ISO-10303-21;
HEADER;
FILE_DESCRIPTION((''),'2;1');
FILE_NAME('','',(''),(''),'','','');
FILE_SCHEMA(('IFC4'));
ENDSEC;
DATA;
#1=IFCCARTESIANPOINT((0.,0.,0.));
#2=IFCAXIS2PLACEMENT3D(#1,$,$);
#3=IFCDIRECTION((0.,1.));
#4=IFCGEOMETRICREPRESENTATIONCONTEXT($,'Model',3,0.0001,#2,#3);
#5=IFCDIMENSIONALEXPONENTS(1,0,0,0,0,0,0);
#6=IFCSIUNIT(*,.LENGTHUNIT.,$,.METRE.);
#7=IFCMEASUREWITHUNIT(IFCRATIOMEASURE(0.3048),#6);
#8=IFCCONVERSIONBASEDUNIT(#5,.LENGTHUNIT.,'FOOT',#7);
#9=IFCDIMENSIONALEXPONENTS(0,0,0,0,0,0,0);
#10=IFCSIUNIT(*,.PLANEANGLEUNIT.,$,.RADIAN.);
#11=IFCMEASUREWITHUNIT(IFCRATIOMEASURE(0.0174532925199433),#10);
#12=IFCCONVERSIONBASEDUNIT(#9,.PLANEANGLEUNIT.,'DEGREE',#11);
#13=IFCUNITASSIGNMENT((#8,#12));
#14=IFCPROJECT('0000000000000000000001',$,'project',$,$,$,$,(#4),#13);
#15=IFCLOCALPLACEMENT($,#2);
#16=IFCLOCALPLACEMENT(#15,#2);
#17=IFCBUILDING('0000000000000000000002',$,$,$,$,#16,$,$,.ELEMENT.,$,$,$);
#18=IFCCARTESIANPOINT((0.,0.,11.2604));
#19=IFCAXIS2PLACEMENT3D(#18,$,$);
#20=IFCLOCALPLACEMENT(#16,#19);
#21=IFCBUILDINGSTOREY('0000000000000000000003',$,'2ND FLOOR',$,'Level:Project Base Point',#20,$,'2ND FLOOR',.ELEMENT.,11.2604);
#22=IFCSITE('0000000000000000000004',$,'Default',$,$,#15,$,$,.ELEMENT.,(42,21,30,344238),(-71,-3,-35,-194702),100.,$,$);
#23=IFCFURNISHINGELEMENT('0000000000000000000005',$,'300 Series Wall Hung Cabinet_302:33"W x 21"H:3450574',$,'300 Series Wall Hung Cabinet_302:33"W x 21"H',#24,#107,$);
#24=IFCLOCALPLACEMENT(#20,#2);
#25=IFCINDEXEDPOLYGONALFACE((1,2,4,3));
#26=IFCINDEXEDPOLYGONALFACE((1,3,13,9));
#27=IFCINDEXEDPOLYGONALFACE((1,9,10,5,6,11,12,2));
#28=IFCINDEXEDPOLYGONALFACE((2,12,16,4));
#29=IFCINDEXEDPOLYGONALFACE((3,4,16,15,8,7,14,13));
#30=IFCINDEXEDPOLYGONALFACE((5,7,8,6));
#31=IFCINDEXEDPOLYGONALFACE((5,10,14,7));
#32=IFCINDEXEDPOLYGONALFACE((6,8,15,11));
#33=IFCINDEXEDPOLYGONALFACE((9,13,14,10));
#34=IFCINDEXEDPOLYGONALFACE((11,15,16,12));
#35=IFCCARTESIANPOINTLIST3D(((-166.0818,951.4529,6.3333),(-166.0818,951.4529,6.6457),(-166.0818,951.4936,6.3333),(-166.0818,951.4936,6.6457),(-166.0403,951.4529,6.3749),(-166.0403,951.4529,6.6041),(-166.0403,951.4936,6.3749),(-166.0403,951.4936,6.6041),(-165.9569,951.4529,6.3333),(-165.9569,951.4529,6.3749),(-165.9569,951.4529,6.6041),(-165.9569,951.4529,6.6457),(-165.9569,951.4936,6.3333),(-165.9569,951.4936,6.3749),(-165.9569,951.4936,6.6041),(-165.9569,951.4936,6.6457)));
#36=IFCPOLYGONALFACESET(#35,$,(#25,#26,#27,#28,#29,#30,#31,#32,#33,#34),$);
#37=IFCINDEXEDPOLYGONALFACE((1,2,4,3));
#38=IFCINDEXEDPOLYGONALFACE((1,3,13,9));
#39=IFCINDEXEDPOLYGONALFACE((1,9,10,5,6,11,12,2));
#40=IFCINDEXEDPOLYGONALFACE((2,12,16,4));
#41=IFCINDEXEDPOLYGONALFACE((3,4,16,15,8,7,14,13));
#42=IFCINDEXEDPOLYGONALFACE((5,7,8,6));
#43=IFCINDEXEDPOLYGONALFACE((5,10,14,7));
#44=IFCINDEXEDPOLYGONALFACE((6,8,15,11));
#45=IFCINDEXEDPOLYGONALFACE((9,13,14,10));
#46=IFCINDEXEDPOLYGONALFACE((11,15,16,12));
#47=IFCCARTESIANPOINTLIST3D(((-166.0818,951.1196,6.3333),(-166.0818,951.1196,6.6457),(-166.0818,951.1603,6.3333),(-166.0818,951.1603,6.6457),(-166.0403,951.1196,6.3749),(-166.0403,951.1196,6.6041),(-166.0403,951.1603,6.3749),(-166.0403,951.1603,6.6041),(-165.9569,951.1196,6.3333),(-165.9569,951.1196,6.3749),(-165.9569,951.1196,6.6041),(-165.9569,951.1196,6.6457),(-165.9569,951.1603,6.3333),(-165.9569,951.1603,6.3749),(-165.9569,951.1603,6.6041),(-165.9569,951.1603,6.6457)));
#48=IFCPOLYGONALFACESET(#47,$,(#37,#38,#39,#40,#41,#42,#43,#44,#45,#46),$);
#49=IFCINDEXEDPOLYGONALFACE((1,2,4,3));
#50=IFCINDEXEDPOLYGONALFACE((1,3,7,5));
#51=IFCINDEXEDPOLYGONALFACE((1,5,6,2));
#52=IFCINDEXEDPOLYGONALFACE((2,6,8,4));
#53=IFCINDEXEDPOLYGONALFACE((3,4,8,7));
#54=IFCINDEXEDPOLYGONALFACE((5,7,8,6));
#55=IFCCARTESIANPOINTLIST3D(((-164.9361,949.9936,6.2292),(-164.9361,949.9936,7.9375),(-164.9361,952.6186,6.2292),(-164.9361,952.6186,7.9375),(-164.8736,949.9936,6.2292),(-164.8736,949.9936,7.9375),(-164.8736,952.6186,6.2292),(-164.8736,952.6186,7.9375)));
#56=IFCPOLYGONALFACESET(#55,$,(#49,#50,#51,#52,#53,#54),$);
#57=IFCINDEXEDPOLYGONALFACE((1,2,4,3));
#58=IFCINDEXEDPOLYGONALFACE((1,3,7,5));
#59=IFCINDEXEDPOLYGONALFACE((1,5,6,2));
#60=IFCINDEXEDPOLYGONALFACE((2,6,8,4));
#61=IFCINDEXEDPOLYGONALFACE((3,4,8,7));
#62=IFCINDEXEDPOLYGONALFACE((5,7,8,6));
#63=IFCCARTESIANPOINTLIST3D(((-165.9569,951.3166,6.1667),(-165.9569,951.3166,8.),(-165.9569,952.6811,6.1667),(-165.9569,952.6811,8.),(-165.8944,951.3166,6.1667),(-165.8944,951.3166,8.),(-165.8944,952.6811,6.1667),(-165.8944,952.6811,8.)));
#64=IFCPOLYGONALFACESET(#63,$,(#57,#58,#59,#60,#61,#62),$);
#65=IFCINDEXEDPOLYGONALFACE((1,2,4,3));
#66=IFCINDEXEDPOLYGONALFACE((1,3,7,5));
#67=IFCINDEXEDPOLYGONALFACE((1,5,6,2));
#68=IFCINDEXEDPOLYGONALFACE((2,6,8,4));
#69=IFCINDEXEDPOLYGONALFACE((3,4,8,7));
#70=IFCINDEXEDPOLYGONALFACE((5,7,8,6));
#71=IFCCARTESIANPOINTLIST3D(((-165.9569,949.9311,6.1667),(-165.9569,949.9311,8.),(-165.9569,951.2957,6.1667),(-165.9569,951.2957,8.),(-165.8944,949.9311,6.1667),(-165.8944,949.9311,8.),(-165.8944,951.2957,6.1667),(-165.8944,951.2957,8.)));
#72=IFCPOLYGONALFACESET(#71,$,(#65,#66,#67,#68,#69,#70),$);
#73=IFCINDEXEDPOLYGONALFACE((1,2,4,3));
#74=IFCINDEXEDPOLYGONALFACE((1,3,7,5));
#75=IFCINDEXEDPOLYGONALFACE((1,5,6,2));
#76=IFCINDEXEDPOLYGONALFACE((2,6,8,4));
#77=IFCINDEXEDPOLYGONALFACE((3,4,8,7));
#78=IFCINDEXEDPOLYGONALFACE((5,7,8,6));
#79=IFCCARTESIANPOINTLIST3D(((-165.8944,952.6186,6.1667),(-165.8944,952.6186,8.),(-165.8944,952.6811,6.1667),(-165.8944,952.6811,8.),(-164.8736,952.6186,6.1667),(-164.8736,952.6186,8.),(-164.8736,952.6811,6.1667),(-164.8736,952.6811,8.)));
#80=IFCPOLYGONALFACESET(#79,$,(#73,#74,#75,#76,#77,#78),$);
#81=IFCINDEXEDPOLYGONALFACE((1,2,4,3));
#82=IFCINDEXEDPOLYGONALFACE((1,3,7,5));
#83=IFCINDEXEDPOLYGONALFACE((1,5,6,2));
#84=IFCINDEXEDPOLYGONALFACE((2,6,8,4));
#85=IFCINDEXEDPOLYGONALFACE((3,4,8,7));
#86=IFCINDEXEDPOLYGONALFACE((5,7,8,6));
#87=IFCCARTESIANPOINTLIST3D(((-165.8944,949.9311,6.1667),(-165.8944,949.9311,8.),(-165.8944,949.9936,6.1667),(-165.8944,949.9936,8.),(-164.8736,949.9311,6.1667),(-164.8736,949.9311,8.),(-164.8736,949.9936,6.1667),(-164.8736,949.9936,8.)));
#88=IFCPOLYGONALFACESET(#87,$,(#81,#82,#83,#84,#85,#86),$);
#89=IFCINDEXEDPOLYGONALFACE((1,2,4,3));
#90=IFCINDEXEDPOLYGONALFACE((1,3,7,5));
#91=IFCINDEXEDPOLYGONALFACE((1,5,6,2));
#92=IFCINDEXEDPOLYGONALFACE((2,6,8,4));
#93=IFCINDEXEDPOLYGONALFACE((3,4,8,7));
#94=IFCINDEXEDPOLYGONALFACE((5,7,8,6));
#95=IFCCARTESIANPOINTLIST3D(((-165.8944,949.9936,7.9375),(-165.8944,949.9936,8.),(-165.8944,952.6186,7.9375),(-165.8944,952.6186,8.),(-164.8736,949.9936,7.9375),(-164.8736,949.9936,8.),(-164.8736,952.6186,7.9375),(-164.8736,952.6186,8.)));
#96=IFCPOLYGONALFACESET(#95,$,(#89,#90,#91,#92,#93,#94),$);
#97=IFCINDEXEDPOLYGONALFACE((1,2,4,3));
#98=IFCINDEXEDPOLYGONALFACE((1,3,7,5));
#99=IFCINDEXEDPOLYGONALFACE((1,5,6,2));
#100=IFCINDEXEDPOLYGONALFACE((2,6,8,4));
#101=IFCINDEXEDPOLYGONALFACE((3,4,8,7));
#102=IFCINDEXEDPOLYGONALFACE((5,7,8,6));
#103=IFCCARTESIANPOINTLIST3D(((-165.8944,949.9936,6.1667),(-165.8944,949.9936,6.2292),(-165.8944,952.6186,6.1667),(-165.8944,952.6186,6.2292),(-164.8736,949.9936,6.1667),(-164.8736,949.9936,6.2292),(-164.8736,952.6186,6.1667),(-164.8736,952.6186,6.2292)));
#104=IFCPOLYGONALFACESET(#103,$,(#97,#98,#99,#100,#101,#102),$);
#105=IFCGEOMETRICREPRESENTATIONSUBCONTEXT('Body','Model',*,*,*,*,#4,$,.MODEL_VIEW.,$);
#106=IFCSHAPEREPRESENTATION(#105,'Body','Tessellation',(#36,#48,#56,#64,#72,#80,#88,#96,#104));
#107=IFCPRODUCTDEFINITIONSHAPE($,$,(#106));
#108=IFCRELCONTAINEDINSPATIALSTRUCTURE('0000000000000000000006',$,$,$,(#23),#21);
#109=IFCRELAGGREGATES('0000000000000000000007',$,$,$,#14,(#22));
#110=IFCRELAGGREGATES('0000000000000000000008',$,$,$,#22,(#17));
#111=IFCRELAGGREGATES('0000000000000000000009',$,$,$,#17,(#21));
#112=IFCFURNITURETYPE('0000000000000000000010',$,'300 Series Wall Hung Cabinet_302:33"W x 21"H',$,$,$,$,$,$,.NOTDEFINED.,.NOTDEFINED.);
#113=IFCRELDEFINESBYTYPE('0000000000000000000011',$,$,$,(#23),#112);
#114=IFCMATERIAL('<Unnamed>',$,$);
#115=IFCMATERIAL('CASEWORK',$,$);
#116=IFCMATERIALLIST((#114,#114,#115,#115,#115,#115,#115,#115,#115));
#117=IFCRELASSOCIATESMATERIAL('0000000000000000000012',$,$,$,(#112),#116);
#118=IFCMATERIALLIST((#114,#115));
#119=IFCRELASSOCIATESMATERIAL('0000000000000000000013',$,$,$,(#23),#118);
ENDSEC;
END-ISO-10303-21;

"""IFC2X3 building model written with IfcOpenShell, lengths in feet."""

from ifc_helpers import new_model, entity, si_unit, converted_unit, direction, frame, frame_2d, origin, origin_2d_with_axis, place, context, subcontext, project, spatial, polyline, rectangle, outline, extrude, source, transform, mapped, material, material_list, type_object, type_shapes, element, save


model = new_model("IFC2X3")

# Units and contexts
model_context = context("Model", 3, precision=0.0001, world=origin(), true_north=direction((0.0, 1.0)))
body_context = subcontext(model_context, "Body", "Model", "MODEL_VIEW")
ifc_project = project(units=[converted_unit("LENGTHUNIT", "FOOT", entity("IfcRatioMeasure", 0.3048), si_unit("LENGTHUNIT", "METRE"), dimensions=[1, 0, 0, 0, 0, 0, 0]), converted_unit("PLANEANGLEUNIT", "DEGREE", entity("IfcRatioMeasure", 0.0174532925199433), si_unit("PLANEANGLEUNIT", "RADIAN"), dimensions=[0, 0, 0, 0, 0, 0, 0])], contexts=[model_context])

# Site, building, storey
site_placement = place(None, origin())
site = spatial("IfcSite", under=ifc_project, at=site_placement, Name="Default", CompositionType="ELEMENT", RefLatitude=(42, 21, 30, 344238), RefLongitude=(-71, -3, -35, -194702), RefElevation=100.0)
building_placement = place(site_placement, origin())
building = spatial("IfcBuilding", under=site, at=building_placement, CompositionType="ELEMENT")
storey_placement = place(building_placement, frame((0.0, 0.0, 11.2604)))
storey = spatial("IfcBuildingStorey", under=building, at=storey_placement, Name="2ND FLOOR", ObjectType="Level:Project Base Point", LongName="2ND FLOOR", CompositionType="ELEMENT", Elevation=11.2604)

# Furnishing element
ifc_material_1 = material(Name="<Unnamed>")
ifc_material_2 = material(Name="CASEWORK")
ifc_material_list_1 = material_list([ifc_material_1, ifc_material_2])
ifc_material_list_2 = material_list([ifc_material_1, ifc_material_1, ifc_material_2, ifc_material_2, ifc_material_2, ifc_material_2, ifc_material_2, ifc_material_2, ifc_material_2])
furniture_type_1 = type_object("IfcFurnitureType", Name="300 Series Wall Hung Cabinet_302:33\"W x 21\"H", material=ifc_material_list_2)
shared_shape_1 = source(origin(), body_context, "Body", "SweptSolid", [
    extrude(outline(polyline([(0.1146, -0.0521), (0.1562, -0.0521), (0.1562, 0.0729), (-0.1562, 0.0729), (-0.1562, -0.0521), (-0.1146, -0.0521), (-0.1146, 0.0313), (0.1146, 0.0313), (0.1146, -0.0521)])), frame((1.1875, 0.0729, 0.3229), z_axis=(1.0, 0.0, 0.0), x_axis=(0.0, 0.0, 1.0)), (0.0, 0.0, 1.0), 0.0407),
    extrude(outline(polyline([(0.1146, -0.0521), (0.1562, -0.0521), (0.1562, 0.0729), (-0.1562, 0.0729), (-0.1562, -0.0521), (-0.1146, -0.0521), (-0.1146, 0.0313), (0.1146, 0.0313), (0.1146, -0.0521)])), frame((1.5208, 0.0729, 0.3229), z_axis=(1.0, 0.0, 0.0), x_axis=(0.0, 0.0, 1.0)), (0.0, 0.0, 1.0), 0.0407),
    extrude(rectangle(XDim=2.625, YDim=0.0625, at=origin_2d_with_axis()), frame((1.375, 1.177, 0.0625), z_axis=(0.0, 0.0, 1.0), x_axis=(-1.0, 0.0, 0.0)), (0.0, 0.0, 1.0), 1.7083),
    extrude(rectangle(XDim=1.3646, YDim=0.0625, at=frame_2d((0.0, 0.0), x_axis=(1.0, 0.0))), frame((0.6823, 0.1562, 0.0), z_axis=(0.0, 0.0, 1.0), x_axis=(-1.0, 0.0, 0.0)), (0.0, 0.0, 1.0), 1.8333),
    extrude(rectangle(XDim=1.3646, YDim=0.0625, at=origin_2d_with_axis()), frame((2.0677, 0.1562, 0.0), z_axis=(0.0, 0.0, 1.0), x_axis=(-1.0, 0.0, 0.0)), (0.0, 0.0, 1.0), 1.8333),
    extrude(rectangle(XDim=1.0208, YDim=0.0625, at=frame_2d((0.0, 0.0), x_axis=(1.0, 0.0))), frame((0.0313, 0.6979, 0.0), z_axis=(0.0, 0.0, 1.0), x_axis=(0.0, -1.0, 0.0)), (0.0, 0.0, 1.0), 1.8333),
    extrude(rectangle(XDim=1.0208, YDim=0.0625, at=frame_2d((0.0, 0.0), x_axis=(1.0, 0.0))), frame((2.7188, 0.6979, 0.0), z_axis=(0.0, 0.0, 1.0), x_axis=(0.0, -1.0, 0.0)), (0.0, 0.0, 1.0), 1.8333),
    extrude(rectangle(XDim=1.0208, YDim=2.625, at=origin_2d_with_axis()), frame((1.375, 0.6979, 1.7708), z_axis=(0.0, 0.0, 1.0), x_axis=(0.0, 1.0, 0.0)), (0.0, 0.0, 1.0), 0.0625),
    extrude(rectangle(XDim=1.0208, YDim=2.625, at=frame_2d((0.0, 0.0), x_axis=(1.0, 0.0))), frame((1.375, 0.6979, 0.0), z_axis=(0.0, 0.0, 1.0), x_axis=(0.0, 1.0, 0.0)), (0.0, 0.0, 1.0), 0.0625),
])
type_shapes(furniture_type_1, [shared_shape_1])
furnishing_1_placement = place(storey_placement, frame((-166.0818, 952.6811, 6.1667), z_axis=(0.0, 0.0, 1.0), x_axis=(0.0, -1.0, 0.0)))
element("IfcFurnishingElement", 1, at=furnishing_1_placement, inside=storey, type_object=furniture_type_1, material=ifc_material_list_1, Name="300 Series Wall Hung Cabinet_302:33\"W x 21\"H:3450574", ObjectType="300 Series Wall Hung Cabinet_302:33\"W x 21\"H", context=body_context, shape_type="MappedRepresentation", body=[
    mapped(shared_shape_1, transform((0.0, 0.0, 0.0), scale=1.0)),
])

save(model, "model.ifc")
